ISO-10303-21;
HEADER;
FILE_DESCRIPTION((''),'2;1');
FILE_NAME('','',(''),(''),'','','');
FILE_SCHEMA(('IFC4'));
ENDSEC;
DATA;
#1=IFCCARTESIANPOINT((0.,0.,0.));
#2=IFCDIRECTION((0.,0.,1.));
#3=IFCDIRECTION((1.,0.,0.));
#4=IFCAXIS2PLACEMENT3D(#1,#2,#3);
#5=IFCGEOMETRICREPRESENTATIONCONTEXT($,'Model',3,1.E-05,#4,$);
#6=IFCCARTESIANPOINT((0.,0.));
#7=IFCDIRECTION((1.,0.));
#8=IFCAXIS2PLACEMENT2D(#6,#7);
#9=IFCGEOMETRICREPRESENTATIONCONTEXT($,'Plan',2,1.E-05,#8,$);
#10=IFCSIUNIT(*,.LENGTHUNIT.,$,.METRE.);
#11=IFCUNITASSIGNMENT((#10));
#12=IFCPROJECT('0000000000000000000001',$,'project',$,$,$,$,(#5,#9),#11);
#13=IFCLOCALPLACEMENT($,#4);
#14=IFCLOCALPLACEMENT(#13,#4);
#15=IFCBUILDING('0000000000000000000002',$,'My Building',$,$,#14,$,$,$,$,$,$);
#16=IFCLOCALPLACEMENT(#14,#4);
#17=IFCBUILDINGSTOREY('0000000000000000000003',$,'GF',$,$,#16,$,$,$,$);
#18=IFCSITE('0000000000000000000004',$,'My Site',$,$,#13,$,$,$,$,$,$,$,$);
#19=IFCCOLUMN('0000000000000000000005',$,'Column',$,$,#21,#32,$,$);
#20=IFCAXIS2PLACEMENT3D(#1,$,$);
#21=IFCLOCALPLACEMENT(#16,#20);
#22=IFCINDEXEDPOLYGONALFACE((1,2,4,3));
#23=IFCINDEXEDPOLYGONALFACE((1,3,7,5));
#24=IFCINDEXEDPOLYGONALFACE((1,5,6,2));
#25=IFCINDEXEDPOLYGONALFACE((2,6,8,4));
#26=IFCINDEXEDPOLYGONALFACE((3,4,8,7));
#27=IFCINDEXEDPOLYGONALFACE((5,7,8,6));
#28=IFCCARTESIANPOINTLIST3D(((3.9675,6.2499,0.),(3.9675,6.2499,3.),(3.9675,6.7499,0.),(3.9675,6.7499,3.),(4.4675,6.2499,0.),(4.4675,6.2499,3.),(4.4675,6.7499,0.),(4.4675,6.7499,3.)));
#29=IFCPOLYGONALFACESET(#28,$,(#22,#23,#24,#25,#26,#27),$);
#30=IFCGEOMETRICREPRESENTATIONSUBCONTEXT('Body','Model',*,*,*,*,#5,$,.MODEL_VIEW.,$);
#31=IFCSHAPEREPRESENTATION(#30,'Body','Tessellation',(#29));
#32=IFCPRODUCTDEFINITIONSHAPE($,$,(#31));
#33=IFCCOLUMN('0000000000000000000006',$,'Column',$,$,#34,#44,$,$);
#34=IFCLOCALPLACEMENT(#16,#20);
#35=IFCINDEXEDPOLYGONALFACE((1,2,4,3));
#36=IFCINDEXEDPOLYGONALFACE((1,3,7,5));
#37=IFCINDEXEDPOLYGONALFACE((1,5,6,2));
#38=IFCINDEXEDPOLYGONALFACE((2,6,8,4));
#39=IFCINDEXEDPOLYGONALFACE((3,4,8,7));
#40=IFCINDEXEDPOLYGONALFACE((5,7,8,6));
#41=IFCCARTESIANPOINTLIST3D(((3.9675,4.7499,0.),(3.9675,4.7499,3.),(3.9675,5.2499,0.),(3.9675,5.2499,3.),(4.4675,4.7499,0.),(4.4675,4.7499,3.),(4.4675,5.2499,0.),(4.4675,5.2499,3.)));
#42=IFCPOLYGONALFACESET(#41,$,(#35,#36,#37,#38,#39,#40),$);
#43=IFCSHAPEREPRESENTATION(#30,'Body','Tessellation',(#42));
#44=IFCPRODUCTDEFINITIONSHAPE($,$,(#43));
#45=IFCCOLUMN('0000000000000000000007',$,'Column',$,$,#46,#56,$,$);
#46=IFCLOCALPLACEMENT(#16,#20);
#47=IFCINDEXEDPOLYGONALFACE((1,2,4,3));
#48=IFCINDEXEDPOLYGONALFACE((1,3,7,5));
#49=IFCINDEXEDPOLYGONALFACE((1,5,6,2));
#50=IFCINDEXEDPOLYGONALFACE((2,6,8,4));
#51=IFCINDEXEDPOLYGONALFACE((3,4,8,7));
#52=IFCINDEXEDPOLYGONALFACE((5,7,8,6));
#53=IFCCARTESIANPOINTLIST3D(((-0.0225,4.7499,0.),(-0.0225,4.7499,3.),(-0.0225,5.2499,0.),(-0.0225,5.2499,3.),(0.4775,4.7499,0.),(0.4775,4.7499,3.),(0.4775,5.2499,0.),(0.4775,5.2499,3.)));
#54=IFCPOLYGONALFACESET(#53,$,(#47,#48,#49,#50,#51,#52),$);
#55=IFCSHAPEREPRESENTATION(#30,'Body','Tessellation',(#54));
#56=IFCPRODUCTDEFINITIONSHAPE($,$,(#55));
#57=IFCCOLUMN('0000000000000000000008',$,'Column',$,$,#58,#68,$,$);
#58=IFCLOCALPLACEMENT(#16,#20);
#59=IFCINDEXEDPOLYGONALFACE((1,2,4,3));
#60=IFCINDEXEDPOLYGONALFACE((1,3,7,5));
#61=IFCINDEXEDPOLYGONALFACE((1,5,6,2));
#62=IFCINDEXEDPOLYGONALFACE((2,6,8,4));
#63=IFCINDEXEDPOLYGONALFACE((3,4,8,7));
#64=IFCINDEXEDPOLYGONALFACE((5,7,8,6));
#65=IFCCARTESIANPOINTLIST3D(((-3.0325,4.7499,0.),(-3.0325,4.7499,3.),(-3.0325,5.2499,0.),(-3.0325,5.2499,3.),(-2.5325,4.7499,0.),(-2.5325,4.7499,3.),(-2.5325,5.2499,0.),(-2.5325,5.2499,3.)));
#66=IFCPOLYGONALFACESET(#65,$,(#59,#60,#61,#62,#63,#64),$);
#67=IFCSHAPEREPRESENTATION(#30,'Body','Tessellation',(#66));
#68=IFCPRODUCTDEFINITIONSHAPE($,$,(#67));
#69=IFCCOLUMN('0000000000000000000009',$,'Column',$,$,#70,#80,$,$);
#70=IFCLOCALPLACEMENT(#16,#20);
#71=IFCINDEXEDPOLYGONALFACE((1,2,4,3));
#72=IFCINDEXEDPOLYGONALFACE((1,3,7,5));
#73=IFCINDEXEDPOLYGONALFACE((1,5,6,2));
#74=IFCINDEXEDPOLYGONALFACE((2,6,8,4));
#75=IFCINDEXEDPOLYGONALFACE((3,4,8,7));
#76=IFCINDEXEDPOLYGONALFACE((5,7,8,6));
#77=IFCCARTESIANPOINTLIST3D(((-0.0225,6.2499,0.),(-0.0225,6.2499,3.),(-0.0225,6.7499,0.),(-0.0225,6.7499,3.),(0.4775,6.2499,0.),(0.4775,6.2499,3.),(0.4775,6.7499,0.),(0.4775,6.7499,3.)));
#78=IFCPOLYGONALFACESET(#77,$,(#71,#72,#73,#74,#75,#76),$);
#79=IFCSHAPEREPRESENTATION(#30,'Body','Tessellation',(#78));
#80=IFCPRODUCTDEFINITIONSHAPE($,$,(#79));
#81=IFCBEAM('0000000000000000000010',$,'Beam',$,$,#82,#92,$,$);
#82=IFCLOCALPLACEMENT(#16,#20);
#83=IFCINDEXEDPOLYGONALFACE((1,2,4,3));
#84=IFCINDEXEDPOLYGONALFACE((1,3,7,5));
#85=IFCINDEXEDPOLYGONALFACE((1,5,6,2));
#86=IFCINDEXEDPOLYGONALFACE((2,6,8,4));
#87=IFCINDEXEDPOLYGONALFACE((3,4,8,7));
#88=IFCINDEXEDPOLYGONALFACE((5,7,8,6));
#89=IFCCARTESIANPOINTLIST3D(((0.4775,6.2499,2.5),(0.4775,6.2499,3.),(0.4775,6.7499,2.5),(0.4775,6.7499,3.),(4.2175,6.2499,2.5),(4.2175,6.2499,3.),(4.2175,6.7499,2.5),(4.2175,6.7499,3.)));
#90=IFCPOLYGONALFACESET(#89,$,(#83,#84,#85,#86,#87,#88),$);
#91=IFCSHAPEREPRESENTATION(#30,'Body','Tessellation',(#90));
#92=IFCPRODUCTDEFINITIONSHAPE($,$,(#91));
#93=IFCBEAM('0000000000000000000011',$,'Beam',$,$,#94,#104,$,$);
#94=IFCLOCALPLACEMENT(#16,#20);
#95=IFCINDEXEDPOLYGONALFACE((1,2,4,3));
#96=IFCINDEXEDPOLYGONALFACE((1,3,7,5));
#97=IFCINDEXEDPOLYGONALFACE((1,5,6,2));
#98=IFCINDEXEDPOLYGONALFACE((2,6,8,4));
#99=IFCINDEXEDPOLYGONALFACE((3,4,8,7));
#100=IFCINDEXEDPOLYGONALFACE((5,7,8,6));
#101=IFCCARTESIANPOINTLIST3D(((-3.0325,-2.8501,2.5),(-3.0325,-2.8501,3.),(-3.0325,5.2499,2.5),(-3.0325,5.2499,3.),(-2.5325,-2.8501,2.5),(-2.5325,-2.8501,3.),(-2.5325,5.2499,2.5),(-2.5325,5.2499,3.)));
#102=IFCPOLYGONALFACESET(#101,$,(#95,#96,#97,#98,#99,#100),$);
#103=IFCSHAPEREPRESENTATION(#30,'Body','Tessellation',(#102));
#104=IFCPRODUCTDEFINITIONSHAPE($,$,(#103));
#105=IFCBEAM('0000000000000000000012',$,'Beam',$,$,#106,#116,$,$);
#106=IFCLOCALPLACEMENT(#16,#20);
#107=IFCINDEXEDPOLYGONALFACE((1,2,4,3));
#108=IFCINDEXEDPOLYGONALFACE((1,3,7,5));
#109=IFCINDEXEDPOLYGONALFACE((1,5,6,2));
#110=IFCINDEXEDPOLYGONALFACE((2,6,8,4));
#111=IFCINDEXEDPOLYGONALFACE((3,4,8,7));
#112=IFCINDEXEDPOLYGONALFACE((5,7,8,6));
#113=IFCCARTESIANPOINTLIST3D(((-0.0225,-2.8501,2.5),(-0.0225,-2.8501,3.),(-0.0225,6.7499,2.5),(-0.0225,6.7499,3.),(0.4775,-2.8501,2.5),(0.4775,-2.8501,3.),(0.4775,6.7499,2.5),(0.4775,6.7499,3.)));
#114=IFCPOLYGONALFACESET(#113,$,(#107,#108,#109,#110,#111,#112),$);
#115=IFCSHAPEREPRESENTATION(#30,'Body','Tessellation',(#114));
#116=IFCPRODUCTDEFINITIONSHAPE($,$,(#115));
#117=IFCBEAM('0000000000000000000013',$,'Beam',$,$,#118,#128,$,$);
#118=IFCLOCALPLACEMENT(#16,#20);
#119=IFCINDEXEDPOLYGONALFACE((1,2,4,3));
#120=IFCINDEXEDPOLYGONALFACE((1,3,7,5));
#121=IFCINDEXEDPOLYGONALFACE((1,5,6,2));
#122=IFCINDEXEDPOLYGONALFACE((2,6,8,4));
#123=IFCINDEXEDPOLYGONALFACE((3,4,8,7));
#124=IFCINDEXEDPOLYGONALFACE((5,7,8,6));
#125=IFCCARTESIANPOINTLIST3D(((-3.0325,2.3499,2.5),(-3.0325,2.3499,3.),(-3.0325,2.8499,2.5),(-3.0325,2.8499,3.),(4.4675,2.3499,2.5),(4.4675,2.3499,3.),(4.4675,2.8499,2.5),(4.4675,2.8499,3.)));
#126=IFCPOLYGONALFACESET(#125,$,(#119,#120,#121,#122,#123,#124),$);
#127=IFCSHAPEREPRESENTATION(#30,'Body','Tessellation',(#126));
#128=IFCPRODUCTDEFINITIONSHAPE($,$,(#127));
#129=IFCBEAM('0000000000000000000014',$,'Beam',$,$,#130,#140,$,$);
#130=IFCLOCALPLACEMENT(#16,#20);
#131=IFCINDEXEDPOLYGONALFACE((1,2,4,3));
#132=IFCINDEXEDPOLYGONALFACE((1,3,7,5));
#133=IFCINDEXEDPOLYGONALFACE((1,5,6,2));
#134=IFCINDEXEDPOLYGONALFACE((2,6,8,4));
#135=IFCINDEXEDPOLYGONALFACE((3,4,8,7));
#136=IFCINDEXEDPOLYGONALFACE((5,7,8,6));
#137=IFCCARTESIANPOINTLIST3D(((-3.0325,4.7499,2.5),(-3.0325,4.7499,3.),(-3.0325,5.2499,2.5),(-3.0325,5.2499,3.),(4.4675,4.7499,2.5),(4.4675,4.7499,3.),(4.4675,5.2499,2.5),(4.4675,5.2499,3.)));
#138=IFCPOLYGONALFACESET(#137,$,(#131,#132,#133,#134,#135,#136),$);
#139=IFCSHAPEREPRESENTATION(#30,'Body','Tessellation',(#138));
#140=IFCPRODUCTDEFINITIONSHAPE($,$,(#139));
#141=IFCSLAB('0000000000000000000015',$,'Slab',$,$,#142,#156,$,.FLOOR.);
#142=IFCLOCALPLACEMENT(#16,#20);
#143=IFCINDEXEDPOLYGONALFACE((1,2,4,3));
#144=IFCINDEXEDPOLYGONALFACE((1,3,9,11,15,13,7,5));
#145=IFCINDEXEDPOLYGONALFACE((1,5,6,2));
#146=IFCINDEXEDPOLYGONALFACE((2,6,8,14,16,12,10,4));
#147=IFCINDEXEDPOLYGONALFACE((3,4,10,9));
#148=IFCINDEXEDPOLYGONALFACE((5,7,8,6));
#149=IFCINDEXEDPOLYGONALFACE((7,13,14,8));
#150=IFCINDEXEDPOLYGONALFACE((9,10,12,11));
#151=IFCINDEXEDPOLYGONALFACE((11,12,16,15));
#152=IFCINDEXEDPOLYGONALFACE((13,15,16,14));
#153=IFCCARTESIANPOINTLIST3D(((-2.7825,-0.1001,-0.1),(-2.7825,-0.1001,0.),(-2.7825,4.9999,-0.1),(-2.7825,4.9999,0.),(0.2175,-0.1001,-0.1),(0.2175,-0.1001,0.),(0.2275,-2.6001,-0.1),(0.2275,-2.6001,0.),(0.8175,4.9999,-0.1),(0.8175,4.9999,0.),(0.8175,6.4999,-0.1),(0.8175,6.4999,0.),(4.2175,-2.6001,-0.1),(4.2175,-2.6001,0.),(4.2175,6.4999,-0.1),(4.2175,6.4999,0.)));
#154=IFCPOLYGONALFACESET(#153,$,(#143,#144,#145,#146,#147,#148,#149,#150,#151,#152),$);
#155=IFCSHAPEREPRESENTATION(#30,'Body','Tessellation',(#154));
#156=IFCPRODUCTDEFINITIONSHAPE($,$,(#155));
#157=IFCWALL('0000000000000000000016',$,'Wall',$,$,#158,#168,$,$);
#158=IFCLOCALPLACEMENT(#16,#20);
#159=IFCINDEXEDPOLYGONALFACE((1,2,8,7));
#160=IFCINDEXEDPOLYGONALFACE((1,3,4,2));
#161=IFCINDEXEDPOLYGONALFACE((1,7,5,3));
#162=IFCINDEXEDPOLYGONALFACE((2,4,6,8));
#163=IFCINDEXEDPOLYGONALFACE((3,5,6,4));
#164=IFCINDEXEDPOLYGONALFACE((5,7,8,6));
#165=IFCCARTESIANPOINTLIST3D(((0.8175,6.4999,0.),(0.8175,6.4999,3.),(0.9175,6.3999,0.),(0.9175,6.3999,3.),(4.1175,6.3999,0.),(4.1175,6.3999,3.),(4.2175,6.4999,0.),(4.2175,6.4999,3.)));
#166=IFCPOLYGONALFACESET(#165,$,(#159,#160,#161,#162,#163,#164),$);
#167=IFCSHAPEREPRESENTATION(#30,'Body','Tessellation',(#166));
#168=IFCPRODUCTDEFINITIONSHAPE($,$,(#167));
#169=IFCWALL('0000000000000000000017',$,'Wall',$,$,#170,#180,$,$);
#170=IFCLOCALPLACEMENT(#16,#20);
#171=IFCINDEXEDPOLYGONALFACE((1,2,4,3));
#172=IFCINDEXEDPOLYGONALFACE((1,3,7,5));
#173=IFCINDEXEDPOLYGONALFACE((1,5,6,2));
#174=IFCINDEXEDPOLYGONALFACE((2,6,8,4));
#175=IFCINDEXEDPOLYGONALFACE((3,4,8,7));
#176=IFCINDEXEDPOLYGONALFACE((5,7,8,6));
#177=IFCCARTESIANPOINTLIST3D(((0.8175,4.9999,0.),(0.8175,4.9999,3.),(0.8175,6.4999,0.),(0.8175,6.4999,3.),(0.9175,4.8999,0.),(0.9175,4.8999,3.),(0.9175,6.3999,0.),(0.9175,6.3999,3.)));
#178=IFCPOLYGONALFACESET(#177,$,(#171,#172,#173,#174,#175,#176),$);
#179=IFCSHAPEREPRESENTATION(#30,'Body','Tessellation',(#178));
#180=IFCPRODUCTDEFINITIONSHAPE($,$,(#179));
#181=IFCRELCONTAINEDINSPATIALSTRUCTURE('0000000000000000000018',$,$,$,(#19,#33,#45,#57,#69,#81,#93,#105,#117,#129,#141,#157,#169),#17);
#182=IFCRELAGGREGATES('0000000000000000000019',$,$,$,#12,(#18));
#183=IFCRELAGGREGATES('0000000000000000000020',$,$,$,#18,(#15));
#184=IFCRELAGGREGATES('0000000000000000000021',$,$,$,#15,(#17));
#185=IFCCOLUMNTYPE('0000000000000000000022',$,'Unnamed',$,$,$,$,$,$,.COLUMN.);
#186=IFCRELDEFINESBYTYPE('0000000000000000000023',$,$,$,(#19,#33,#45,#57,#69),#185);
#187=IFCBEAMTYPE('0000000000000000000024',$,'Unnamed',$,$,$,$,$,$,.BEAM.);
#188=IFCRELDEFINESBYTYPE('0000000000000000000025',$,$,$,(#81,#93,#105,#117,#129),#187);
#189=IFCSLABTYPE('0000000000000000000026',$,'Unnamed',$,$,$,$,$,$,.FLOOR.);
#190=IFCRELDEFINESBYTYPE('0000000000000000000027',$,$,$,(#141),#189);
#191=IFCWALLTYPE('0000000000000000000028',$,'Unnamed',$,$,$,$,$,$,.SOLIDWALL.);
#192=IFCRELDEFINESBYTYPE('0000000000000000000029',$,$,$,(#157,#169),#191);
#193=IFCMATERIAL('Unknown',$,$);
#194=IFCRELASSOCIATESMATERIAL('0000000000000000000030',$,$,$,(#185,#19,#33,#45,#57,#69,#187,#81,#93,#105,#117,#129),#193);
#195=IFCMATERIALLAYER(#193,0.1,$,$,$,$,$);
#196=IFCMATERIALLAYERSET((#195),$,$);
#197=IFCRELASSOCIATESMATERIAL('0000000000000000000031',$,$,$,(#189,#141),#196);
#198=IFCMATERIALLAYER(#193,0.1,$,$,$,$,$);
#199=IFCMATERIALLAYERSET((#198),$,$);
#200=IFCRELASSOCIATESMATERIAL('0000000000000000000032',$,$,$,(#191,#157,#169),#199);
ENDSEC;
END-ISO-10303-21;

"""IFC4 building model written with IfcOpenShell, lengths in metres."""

from ifc_helpers import new_model, si_unit, frame, origin_with_axes, origin_2d_with_axis, place, context, subcontext, project, spatial, line, indexed_curve, rectangle, outline, extrude, material, layer, layer_set, layer_usage, material_profile, profile_set, profile_usage, type_object, element, save


model = new_model("IFC4")

# Units and contexts
model_context = context("Model", 3, precision=1e-05, world=origin_with_axes())
plan_context = context("Plan", 2, precision=1e-05, world=origin_2d_with_axis())
body_context_1 = subcontext(model_context, "Body", "Model", "MODEL_VIEW")
ifc_project = project(units=[si_unit("LENGTHUNIT", "METRE")], contexts=[model_context, plan_context])

# Site, building, storey
site_placement = place(None, origin_with_axes())
site = spatial("IfcSite", under=ifc_project, at=site_placement, Name="My Site")
building_placement = place(site_placement, origin_with_axes())
building = spatial("IfcBuilding", under=site, at=building_placement, Name="My Building")
storey_placement = place(building_placement, origin_with_axes())
storey = spatial("IfcBuildingStorey", under=building, at=storey_placement, Name="GF")

# Columns
ifc_material = material(Name="Unknown")
ifc_material_profile_1 = material_profile(ifc_material, rectangle(XDim=0.5, YDim=0.5))
ifc_profile_set_1 = profile_set([ifc_material_profile_1])
ifc_profile_usage_1 = profile_usage(ifc_profile_set_1, cardinal=5)
column_type = type_object("IfcColumnType", Name="Unnamed", PredefinedType="COLUMN", material=ifc_profile_set_1)
column_1_placement = place(storey_placement, frame((4.2175, 6.4999, 0.0), z_axis=(0.0, 0.0, 1.0), x_axis=(1.0, 0.0, 0.0)))
element("IfcColumn", 1, at=column_1_placement, inside=storey, type_object=column_type, material=ifc_profile_usage_1, Name="Column", context=body_context_1, shape_type="SweptSolid", body=[
    extrude(rectangle(XDim=0.5, YDim=0.5), origin_with_axes(), (0.0, 0.0, 1.0), 3.0),
])
ifc_profile_usage_2 = profile_usage(ifc_profile_set_1, cardinal=5)
column_2_placement = place(storey_placement, frame((4.2175, 4.9999, 0.0), z_axis=(0.0, 0.0, 1.0), x_axis=(1.0, 0.0, 0.0)))
element("IfcColumn", 2, at=column_2_placement, inside=storey, type_object=column_type, material=ifc_profile_usage_2, Name="Column", context=body_context_1, shape_type="SweptSolid", body=[
    extrude(rectangle(XDim=0.5, YDim=0.5), origin_with_axes(), (0.0, 0.0, 1.0), 3.0),
])
ifc_profile_usage_3 = profile_usage(ifc_profile_set_1, cardinal=5)
column_3_placement = place(storey_placement, frame((0.2275, 4.9999, 0.0), z_axis=(0.0, 0.0, 1.0), x_axis=(1.0, 0.0, 0.0)))
element("IfcColumn", 3, at=column_3_placement, inside=storey, type_object=column_type, material=ifc_profile_usage_3, Name="Column", context=body_context_1, shape_type="SweptSolid", body=[
    extrude(rectangle(XDim=0.5, YDim=0.5), origin_with_axes(), (0.0, 0.0, 1.0), 3.0),
])
ifc_profile_usage_4 = profile_usage(ifc_profile_set_1, cardinal=5)
column_4_placement = place(storey_placement, frame((-2.7825, 4.9999, 0.0), z_axis=(0.0, 0.0, 1.0), x_axis=(1.0, 0.0, 0.0)))
element("IfcColumn", 4, at=column_4_placement, inside=storey, type_object=column_type, material=ifc_profile_usage_4, Name="Column", context=body_context_1, shape_type="SweptSolid", body=[
    extrude(rectangle(XDim=0.5, YDim=0.5), origin_with_axes(), (0.0, 0.0, 1.0), 3.0),
])
ifc_profile_usage_5 = profile_usage(ifc_profile_set_1, cardinal=5)
column_5_placement = place(storey_placement, frame((0.2275, 6.4999, 0.0), z_axis=(0.0, 0.0, 1.0), x_axis=(1.0, 0.0, 0.0)))
element("IfcColumn", 5, at=column_5_placement, inside=storey, type_object=column_type, material=ifc_profile_usage_5, Name="Column", context=body_context_1, shape_type="SweptSolid", body=[
    extrude(rectangle(XDim=0.5, YDim=0.5), origin_with_axes(), (0.0, 0.0, 1.0), 3.0),
])

# Beams
ifc_material_profile_2 = material_profile(ifc_material, rectangle(XDim=0.5, YDim=0.5))
ifc_profile_set_2 = profile_set([ifc_material_profile_2])
ifc_profile_usage_6 = profile_usage(ifc_profile_set_2, cardinal=5)
beam_type = type_object("IfcBeamType", Name="Unnamed", PredefinedType="BEAM", material=ifc_profile_set_2)
beam_1_placement = place(storey_placement, frame((0.4775, 6.4999, 2.75), z_axis=(1.0, 0.0, 0.0), x_axis=(0.0, 1.0, 0.0)))
element("IfcBeam", 6, at=beam_1_placement, inside=storey, type_object=beam_type, material=ifc_profile_usage_6, Name="Beam", context=body_context_1, shape_type="SweptSolid", body=[
    extrude(rectangle(XDim=0.5, YDim=0.5), origin_with_axes(), (0.0, 0.0, 1.0), 3.74),
])
ifc_profile_usage_7 = profile_usage(ifc_profile_set_2, cardinal=5)
beam_2_placement = place(storey_placement, frame((-2.7825, 5.2499, 2.75), z_axis=(0.0, -1.0, 0.0), x_axis=(1.0, 0.0, 0.0)))
element("IfcBeam", 7, at=beam_2_placement, inside=storey, type_object=beam_type, material=ifc_profile_usage_7, Name="Beam", context=body_context_1, shape_type="SweptSolid", body=[
    extrude(rectangle(XDim=0.5, YDim=0.5), origin_with_axes(), (0.0, 0.0, 1.0), 8.1),
])
ifc_profile_usage_8 = profile_usage(ifc_profile_set_2, cardinal=5)
beam_3_placement = place(storey_placement, frame((0.2275, 6.7499, 2.75), z_axis=(0.0, -1.0, 0.0), x_axis=(1.0, 0.0, 0.0)))
element("IfcBeam", 8, at=beam_3_placement, inside=storey, type_object=beam_type, material=ifc_profile_usage_8, Name="Beam", context=body_context_1, shape_type="SweptSolid", body=[
    extrude(rectangle(XDim=0.5, YDim=0.5), origin_with_axes(), (0.0, 0.0, 1.0), 9.6),
])
ifc_profile_usage_9 = profile_usage(ifc_profile_set_2, cardinal=5)
beam_4_placement = place(storey_placement, frame((-3.0325, 2.5999, 2.75), z_axis=(1.0, -0.000001, 0.0), x_axis=(0.000001, 1.0, 0.0)))
element("IfcBeam", 9, at=beam_4_placement, inside=storey, type_object=beam_type, material=ifc_profile_usage_9, Name="Beam", context=body_context_1, shape_type="SweptSolid", body=[
    extrude(rectangle(XDim=0.5, YDim=0.5), origin_with_axes(), (0.0, 0.0, 1.0), 7.5),
])
ifc_profile_usage_10 = profile_usage(ifc_profile_set_2, cardinal=5)
beam_5_placement = place(storey_placement, frame((-3.0325, 4.9999, 2.75), z_axis=(1.0, -0.000001, 0.0), x_axis=(0.000001, 1.0, 0.0)))
element("IfcBeam", 10, at=beam_5_placement, inside=storey, type_object=beam_type, material=ifc_profile_usage_10, Name="Beam", context=body_context_1, shape_type="SweptSolid", body=[
    extrude(rectangle(XDim=0.5, YDim=0.5), origin_with_axes(), (0.0, 0.0, 1.0), 7.5),
])

# Slab
ifc_layer_1 = layer(ifc_material, 0.1)
ifc_layer_set_1 = layer_set([ifc_layer_1])
ifc_layer_usage_1 = layer_usage(ifc_layer_set_1, "AXIS3", "POSITIVE", -0.05)
slab_type = type_object("IfcSlabType", Name="Unnamed", PredefinedType="FLOOR", material=ifc_layer_set_1)
slab_placement = place(storey_placement, frame((0.8175, 6.4999, -0.05), z_axis=(0.0, 0.0, 1.0), x_axis=(1.0, 0.0, 0.0)))
element("IfcSlab", 11, at=slab_placement, inside=storey, type_object=slab_type, material=ifc_layer_usage_1, Name="Slab", PredefinedType="FLOOR", context=body_context_1, shape_type="SweptSolid", body=[
    extrude(outline(indexed_curve([(0.0, 0.0), (3.4, 0.0), (3.4, -9.1), (-0.59, -9.1), (-0.6, -6.6), (-3.6, -6.6), (-3.6, -1.5), (0.0, -1.5), (0.0, 0.0)])), frame((0.0, 0.0, -0.05), z_axis=(0.0, 0.0, 1.0), x_axis=(1.0, 0.0, 0.0)), (0.0, 0.0, 1.0), 0.1),
])

# Walls
ifc_layer_2 = layer(ifc_material, 0.1)
ifc_layer_set_2 = layer_set([ifc_layer_2])
ifc_layer_usage_2 = layer_usage(ifc_layer_set_2, "AXIS2", "POSITIVE", 0.0)
wall_type = type_object("IfcWallType", Name="Unnamed", PredefinedType="SOLIDWALL", material=ifc_layer_set_2)
wall_1_placement = place(storey_placement, frame((4.2175, 6.4999, 0.0), z_axis=(0.0, 0.0, 1.0), x_axis=(-1.0, 0.0, 0.0)))
element("IfcWall", 12, at=wall_1_placement, inside=storey, type_object=wall_type, material=ifc_layer_usage_2, Name="Wall", context=body_context_1, shape_type="SweptSolid", body=[
    extrude(outline(indexed_curve([(0.0, 0.0), (0.1, 0.1), (3.3, 0.1), (3.4, 0.0)], segments=[line(1, 2, 3, 4, 1)])), origin_with_axes(), (0.0, 0.0, 1.0), 3.0),
])
ifc_layer_usage_3 = layer_usage(ifc_layer_set_2, "AXIS2", "POSITIVE", 0.0)
wall_2_placement = place(storey_placement, frame((0.8175, 6.4999, 0.0), z_axis=(0.0, 0.0, 1.0), x_axis=(0.0, -1.0, 0.0)))
element("IfcWall", 13, at=wall_2_placement, inside=storey, type_object=wall_type, material=ifc_layer_usage_3, Name="Wall", context=body_context_1, shape_type="SweptSolid", body=[
    extrude(outline(indexed_curve([(0.0, 0.0), (0.1, 0.1), (1.6, 0.1), (1.5, 0.0)], segments=[line(1, 2, 3, 4, 1)])), origin_with_axes(), (0.0, 0.0, 1.0), 3.0),
])

save(model, "model.ifc")
